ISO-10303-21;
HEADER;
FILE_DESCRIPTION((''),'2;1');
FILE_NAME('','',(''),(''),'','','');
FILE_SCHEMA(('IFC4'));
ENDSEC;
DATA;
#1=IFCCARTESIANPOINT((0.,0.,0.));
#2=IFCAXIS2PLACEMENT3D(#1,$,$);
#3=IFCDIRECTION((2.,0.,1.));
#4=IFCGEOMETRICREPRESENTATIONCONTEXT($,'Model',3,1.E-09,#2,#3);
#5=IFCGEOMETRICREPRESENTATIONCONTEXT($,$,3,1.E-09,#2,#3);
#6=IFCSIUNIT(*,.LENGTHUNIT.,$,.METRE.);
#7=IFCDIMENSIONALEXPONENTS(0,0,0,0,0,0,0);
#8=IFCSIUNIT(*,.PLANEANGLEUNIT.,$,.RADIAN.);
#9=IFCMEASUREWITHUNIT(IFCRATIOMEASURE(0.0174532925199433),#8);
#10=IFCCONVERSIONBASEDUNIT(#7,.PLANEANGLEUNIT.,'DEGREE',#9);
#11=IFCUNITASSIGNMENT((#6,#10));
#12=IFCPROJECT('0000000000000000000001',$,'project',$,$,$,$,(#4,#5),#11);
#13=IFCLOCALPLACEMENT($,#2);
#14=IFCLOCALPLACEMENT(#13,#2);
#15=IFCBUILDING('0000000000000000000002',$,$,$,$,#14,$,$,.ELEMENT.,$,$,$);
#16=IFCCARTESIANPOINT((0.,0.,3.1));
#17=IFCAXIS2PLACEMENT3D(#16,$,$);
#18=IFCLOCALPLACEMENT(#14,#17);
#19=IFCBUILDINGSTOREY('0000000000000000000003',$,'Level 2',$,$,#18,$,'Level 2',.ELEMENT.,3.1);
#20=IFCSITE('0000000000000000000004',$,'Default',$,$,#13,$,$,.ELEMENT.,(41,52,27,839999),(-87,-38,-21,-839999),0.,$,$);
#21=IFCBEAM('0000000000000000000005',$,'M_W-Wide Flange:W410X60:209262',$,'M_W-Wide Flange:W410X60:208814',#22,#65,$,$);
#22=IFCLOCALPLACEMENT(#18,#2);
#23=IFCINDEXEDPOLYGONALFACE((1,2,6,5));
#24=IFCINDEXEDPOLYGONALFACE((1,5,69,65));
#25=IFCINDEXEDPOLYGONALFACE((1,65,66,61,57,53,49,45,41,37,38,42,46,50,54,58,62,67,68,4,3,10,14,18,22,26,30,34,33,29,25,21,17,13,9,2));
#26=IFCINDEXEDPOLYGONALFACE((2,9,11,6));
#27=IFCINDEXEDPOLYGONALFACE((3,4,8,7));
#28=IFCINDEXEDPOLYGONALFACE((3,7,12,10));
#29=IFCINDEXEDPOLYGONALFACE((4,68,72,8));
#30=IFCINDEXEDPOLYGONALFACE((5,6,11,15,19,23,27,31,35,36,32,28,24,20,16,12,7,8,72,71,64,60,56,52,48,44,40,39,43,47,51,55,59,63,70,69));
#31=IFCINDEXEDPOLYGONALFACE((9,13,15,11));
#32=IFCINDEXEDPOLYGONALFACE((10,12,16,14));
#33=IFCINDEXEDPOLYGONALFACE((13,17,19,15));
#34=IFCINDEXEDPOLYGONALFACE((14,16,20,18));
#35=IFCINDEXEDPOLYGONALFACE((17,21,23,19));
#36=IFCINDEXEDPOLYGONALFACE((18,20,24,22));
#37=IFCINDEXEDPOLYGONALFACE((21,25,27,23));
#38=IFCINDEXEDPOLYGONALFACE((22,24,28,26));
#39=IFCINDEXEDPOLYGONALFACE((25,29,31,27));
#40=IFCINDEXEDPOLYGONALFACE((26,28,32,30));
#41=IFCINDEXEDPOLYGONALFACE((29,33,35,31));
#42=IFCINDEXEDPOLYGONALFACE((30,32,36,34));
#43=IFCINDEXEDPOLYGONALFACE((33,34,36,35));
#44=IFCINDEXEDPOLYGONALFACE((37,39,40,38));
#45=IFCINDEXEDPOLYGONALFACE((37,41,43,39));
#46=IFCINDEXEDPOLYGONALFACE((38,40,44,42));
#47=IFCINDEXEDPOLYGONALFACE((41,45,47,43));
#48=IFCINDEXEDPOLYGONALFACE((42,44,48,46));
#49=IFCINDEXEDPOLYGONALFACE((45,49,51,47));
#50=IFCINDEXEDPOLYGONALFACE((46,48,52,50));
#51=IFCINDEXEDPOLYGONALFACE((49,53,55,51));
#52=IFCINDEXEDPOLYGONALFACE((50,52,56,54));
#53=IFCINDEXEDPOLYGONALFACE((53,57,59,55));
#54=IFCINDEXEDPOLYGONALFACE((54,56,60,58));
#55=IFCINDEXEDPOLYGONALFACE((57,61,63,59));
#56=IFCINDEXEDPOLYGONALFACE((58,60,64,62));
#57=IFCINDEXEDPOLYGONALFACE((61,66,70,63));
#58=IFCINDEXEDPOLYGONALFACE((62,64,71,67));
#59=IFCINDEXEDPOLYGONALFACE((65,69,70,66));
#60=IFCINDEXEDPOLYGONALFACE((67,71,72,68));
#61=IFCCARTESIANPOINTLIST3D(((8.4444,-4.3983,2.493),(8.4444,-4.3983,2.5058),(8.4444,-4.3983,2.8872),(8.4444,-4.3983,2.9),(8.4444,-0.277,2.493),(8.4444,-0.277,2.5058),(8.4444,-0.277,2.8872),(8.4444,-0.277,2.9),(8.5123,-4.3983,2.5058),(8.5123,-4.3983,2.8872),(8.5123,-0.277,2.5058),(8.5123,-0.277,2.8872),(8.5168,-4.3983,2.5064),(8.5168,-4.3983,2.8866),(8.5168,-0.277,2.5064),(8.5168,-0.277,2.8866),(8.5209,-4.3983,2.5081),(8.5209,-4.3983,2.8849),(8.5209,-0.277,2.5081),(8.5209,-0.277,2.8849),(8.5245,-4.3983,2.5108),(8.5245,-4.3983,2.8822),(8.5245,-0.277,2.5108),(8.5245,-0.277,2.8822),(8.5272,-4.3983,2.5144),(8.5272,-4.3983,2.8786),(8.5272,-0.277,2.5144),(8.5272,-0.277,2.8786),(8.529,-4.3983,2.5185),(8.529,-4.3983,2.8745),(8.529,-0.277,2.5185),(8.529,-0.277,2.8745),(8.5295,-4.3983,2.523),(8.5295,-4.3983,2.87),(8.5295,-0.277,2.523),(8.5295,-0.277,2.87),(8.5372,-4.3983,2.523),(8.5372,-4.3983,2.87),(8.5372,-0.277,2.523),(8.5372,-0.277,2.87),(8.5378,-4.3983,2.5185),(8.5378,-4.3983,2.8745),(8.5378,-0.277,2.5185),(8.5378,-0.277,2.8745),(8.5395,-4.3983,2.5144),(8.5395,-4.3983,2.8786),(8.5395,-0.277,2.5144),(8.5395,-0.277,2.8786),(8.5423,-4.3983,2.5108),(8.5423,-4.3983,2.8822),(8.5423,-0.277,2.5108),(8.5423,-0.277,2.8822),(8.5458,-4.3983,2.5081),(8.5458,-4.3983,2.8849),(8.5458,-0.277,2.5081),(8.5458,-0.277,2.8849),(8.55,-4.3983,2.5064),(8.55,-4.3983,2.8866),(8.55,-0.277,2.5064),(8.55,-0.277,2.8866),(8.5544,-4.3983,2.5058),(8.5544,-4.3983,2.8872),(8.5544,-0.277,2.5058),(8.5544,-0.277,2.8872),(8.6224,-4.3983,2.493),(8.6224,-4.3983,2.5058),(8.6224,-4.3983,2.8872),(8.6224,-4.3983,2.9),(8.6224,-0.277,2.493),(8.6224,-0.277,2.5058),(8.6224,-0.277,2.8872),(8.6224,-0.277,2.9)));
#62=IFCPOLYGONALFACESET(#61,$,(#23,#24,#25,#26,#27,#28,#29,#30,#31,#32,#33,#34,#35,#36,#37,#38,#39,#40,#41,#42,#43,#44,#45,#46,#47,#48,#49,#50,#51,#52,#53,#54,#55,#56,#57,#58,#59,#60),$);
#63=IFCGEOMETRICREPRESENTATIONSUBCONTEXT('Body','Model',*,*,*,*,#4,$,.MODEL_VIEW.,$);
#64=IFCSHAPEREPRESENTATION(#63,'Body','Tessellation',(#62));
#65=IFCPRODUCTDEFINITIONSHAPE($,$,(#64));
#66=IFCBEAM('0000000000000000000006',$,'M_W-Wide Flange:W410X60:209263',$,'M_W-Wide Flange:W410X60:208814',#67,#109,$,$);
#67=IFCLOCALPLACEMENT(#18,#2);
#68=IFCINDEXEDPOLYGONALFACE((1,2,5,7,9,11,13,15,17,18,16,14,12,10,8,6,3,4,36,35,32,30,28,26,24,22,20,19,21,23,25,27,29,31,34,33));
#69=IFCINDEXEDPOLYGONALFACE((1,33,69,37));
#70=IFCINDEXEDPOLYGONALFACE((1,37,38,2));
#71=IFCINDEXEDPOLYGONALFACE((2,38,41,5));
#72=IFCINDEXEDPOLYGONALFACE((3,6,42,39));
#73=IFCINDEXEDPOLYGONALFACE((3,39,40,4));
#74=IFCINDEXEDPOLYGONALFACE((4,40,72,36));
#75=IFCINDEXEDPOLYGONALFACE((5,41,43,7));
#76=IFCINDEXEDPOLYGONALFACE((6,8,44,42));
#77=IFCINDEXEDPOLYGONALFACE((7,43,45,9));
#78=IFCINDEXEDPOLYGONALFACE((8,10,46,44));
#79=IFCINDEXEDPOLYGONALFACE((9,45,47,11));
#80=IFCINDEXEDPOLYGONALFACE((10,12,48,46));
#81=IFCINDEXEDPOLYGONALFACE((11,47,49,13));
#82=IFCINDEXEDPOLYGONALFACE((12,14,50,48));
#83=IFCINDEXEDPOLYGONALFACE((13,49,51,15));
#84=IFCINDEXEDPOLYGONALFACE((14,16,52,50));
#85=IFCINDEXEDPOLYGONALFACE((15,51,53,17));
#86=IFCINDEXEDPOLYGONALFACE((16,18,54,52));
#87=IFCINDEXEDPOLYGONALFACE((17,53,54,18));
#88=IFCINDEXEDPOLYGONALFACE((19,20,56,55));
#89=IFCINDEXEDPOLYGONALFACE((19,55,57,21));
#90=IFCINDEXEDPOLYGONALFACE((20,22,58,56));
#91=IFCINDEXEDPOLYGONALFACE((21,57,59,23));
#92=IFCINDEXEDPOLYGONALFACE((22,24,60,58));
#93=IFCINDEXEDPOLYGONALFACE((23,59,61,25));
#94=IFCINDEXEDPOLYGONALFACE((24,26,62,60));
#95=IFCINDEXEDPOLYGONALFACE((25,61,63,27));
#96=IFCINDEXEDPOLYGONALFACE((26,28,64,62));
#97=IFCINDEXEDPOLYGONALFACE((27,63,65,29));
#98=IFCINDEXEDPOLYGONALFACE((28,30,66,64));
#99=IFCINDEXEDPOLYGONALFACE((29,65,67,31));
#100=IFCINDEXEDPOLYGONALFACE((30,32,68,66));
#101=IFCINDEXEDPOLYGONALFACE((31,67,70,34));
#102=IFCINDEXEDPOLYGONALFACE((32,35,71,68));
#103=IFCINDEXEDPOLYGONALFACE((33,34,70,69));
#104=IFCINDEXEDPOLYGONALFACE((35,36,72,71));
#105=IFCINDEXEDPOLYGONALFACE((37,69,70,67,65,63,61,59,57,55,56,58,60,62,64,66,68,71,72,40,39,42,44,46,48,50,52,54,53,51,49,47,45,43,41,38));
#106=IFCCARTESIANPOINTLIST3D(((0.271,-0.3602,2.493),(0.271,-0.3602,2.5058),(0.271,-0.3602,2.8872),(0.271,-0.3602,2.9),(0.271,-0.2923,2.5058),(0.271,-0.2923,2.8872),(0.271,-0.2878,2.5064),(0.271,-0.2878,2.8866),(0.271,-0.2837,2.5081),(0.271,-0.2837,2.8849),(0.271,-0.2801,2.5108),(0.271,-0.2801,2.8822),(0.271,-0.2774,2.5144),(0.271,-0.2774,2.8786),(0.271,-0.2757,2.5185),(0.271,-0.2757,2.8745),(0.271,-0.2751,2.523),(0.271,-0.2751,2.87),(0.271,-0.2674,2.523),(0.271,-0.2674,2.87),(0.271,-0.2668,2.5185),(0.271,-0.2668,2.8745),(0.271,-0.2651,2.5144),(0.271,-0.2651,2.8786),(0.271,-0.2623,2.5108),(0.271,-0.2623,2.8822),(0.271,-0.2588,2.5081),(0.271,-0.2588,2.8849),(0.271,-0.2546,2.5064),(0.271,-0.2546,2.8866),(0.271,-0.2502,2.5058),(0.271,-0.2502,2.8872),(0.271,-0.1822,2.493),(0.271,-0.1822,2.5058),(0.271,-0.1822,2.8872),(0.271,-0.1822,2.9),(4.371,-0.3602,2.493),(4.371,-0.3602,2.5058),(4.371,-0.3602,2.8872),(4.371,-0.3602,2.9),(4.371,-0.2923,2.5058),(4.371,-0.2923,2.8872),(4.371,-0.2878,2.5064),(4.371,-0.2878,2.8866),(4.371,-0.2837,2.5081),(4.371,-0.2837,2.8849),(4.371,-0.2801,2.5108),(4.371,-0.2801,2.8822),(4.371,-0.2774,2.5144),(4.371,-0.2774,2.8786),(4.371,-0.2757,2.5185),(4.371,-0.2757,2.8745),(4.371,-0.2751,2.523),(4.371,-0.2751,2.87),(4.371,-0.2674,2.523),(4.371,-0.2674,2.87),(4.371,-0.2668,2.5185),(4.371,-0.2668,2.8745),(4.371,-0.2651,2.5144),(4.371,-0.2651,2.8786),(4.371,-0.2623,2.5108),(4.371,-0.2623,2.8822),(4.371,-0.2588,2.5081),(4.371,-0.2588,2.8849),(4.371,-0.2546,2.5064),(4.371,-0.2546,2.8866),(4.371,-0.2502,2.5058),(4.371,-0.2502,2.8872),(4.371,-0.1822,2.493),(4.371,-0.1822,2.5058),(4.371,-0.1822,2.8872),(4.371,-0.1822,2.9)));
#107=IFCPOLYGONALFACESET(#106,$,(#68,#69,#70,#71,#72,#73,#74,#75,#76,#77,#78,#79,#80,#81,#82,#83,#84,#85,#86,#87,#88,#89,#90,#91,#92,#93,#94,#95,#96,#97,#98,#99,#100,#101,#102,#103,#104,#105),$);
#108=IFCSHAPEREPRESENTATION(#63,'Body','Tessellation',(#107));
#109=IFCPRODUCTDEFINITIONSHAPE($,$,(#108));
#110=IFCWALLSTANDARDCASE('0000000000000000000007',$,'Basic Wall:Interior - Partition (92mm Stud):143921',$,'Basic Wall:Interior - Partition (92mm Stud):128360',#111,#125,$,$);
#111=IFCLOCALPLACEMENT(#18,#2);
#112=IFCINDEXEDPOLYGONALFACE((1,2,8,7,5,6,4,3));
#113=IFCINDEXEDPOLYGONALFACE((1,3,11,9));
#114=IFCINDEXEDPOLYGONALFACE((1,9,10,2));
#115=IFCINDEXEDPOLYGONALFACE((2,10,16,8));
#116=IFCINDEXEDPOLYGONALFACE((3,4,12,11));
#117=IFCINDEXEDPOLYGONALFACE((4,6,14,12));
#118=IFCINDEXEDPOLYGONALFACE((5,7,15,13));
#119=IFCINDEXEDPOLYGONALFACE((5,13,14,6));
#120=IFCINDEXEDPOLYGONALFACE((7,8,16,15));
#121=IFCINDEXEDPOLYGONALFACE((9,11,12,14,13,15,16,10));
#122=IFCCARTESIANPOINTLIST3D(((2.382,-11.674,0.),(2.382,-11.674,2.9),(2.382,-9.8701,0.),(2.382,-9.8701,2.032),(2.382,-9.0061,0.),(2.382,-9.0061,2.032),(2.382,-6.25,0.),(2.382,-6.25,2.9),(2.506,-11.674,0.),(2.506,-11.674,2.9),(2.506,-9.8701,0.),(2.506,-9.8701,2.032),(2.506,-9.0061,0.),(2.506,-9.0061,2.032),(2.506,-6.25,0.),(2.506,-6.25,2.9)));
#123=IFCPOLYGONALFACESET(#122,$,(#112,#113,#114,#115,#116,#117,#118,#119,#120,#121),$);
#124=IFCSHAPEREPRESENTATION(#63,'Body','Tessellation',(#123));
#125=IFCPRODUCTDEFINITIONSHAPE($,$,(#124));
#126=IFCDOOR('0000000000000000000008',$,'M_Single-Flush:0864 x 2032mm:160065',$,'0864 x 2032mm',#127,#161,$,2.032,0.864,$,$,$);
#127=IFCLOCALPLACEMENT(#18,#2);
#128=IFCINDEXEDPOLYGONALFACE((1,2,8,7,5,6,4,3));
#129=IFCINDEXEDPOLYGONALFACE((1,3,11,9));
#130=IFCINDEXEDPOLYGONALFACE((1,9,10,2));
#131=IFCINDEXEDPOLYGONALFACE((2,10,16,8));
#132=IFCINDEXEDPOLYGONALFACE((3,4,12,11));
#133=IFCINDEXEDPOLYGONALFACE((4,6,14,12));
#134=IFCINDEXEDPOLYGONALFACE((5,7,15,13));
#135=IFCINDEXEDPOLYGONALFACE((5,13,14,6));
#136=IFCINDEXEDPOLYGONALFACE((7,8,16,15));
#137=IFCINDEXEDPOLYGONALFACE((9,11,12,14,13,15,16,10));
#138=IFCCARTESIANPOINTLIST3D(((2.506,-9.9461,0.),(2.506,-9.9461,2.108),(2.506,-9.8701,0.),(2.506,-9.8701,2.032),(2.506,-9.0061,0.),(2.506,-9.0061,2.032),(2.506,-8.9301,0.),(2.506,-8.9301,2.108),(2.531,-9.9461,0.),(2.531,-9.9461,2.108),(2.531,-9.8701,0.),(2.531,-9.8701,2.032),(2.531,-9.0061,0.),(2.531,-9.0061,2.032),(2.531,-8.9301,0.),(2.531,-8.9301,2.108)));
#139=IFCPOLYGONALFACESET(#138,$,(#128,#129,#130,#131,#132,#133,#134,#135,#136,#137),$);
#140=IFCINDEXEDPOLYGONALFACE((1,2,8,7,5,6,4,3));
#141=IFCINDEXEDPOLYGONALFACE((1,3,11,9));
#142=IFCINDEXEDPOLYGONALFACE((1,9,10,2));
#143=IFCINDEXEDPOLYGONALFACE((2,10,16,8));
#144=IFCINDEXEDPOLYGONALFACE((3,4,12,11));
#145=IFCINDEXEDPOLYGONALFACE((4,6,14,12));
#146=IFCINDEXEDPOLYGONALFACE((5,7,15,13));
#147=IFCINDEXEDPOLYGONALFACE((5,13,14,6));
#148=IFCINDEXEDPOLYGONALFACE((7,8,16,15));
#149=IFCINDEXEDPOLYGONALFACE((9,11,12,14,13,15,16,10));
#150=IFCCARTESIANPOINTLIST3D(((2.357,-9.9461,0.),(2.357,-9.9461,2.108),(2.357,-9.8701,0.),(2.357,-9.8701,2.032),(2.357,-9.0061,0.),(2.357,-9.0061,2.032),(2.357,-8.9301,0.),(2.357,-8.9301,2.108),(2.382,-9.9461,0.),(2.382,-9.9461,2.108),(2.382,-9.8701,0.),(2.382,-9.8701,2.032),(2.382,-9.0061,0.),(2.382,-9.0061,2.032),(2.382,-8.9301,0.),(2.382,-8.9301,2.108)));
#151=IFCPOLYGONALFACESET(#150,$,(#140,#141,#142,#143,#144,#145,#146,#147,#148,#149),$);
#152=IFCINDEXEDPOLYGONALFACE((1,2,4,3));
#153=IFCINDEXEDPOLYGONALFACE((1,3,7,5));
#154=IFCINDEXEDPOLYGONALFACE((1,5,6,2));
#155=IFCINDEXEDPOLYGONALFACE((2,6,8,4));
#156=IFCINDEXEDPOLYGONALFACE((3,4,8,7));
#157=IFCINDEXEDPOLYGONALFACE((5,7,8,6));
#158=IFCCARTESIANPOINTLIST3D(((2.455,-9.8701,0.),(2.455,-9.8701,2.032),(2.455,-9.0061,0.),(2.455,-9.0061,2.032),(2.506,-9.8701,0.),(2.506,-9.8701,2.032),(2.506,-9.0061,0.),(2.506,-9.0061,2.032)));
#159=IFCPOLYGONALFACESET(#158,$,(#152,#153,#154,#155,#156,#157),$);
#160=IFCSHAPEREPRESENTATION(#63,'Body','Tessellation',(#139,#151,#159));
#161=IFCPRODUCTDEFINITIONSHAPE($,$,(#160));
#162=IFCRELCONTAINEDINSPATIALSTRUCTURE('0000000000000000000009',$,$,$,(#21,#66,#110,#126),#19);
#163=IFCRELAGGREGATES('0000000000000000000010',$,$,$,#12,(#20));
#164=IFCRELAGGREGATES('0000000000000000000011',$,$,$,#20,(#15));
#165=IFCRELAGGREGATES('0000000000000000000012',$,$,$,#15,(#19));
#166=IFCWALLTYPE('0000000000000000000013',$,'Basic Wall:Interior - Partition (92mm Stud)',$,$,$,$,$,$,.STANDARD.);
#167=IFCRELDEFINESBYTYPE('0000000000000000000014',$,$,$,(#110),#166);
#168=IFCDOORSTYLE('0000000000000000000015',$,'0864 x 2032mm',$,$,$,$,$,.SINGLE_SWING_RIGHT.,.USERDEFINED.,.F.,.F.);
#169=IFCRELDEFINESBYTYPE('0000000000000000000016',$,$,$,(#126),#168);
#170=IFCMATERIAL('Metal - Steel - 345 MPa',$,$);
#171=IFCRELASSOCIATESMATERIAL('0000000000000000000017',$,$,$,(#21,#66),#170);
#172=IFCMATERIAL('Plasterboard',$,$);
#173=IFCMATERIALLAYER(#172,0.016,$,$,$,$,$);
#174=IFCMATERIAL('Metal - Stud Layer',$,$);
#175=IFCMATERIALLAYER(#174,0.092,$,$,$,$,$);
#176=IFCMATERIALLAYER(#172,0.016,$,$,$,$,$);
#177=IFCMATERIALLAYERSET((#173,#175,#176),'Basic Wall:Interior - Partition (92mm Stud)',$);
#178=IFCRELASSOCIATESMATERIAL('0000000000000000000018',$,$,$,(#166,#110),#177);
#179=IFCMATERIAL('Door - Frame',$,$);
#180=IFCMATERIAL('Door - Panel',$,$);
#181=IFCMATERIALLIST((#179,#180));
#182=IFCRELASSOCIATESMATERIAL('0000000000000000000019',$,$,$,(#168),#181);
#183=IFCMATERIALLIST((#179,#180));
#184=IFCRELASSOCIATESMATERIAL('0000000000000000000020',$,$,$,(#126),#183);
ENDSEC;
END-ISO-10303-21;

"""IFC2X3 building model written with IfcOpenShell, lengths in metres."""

from ifc_helpers import new_model, entity, si_unit, converted_unit, direction, frame, frame_2d, origin, origin_2d_with_axis, place, context, subcontext, project, spatial, polyline, rectangle, i_section, outline, extrude, source, transform, mapped, material, material_list, layer, layer_set, layer_usage, type_object, type_shapes, element, fill, save


model = new_model("IFC2X3")

# Units and contexts
model_context = context("Model", 3, precision=1e-09, world=origin(), true_north=direction((2.0, 0.0, 1.0)))
context_of_model = context(None, 3, precision=1e-09, world=origin(), true_north=direction((2.0, 0.0, 1.0)))
body_context = subcontext(model_context, "Body", "Model", "MODEL_VIEW")
ifc_project = project(units=[si_unit("LENGTHUNIT", "METRE"), converted_unit("PLANEANGLEUNIT", "DEGREE", entity("IfcRatioMeasure", 0.0174532925199433), si_unit("PLANEANGLEUNIT", "RADIAN"), dimensions=[0, 0, 0, 0, 0, 0, 0])], contexts=[model_context, context_of_model])

# Site, building, storey
site_placement = place(None, origin())
site = spatial("IfcSite", under=ifc_project, at=site_placement, Name="Default", CompositionType="ELEMENT", RefLatitude=(41, 52, 27, 839999), RefLongitude=(-87, -38, -21, -839999), RefElevation=0.0)
building_placement = place(site_placement, origin())
building = spatial("IfcBuilding", under=site, at=building_placement, CompositionType="ELEMENT")
storey_placement = place(building_placement, frame((0.0, 0.0, 3.1)))
storey = spatial("IfcBuildingStorey", under=building, at=storey_placement, Name="Level 2", LongName="Level 2", CompositionType="ELEMENT", Elevation=3.1)

# Beams
ifc_material_1 = material(Name="Metal - Steel - 345 MPa")
beam_1_placement = place(storey_placement, frame((8.5334, -4.3983, 2.9), z_axis=(0.0, 0.0, 1.0), x_axis=(0.0, 1.0, 0.0)))
element("IfcBeam", 1, at=beam_1_placement, inside=storey, material=ifc_material_1, Name="M_W-Wide Flange:W410X60:209262", ObjectType="M_W-Wide Flange:W410X60:208814", context=body_context, shape_type="SweptSolid", body=[
    extrude(i_section(OverallWidth=0.178, OverallDepth=0.407, WebThickness=0.0077, FlangeThickness=0.0128, FilletRadius=0.0172, at=frame_2d((0.0, 0.0), x_axis=(0.0, 1.0))), frame((0.0, 0.0, -0.2035), z_axis=(1.0, 0.0, 0.0), x_axis=(0.0, 0.0, -1.0)), (0.0, 0.0, 1.0), 4.1213),
])
beam_2_placement = place(storey_placement, frame((4.371, -0.2712, 2.9), z_axis=(0.0, 0.0, 1.0), x_axis=(-1.0, 0.0, 0.0)))
element("IfcBeam", 2, at=beam_2_placement, inside=storey, material=ifc_material_1, Name="M_W-Wide Flange:W410X60:209263", ObjectType="M_W-Wide Flange:W410X60:208814", context=body_context, shape_type="SweptSolid", body=[
    extrude(i_section(OverallWidth=0.178, OverallDepth=0.407, WebThickness=0.0077, FlangeThickness=0.0128, FilletRadius=0.0172, at=frame_2d((0.0, 0.0), x_axis=(0.0, 1.0))), frame((0.0, 0.0, -0.2035), z_axis=(1.0, 0.0, 0.0), x_axis=(0.0, 0.0, -1.0)), (0.0, 0.0, 1.0), 4.1),
])

# Shared definitions
ifc_material_2 = material(Name="Metal - Stud Layer")
ifc_material_3 = material(Name="Plasterboard")

# Wall, opening, door
ifc_layer_1 = layer(ifc_material_3, 0.016)
ifc_layer_2 = layer(ifc_material_2, 0.092)
ifc_layer_3 = layer(ifc_material_3, 0.016)
ifc_layer_set_1 = layer_set([ifc_layer_1, ifc_layer_2, ifc_layer_3], Name="Basic Wall:Interior - Partition (92mm Stud)")
ifc_layer_usage_1 = layer_usage(ifc_layer_set_1, "AXIS2", "NEGATIVE", 0.062)
wall_type_1 = type_object("IfcWallType", Name="Basic Wall:Interior - Partition (92mm Stud)", PredefinedType="STANDARD", material=ifc_layer_set_1)
wall_1_placement = place(storey_placement, frame((2.444, -6.25, 0.0), z_axis=(0.0, 0.0, 1.0), x_axis=(0.0, -1.0, 0.0)))
wall_1 = element("IfcWallStandardCase", 3, at=wall_1_placement, inside=storey, type_object=wall_type_1, material=ifc_layer_usage_1, Name="Basic Wall:Interior - Partition (92mm Stud):143921", ObjectType="Basic Wall:Interior - Partition (92mm Stud):128360", context=body_context, shape_type="SweptSolid", body=[
    extrude(rectangle(XDim=5.424, YDim=0.124, at=frame_2d((2.712, 0.0), x_axis=(-1.0, 0.0))), origin(), (0.0, 0.0, 1.0), 2.9),
])
opening_1_placement = place(wall_1_placement, frame((2.7561, -0.062, 0.0)))
opening_1 = element("IfcOpeningElement", 4, at=opening_1_placement, cuts=wall_1, ObjectType="Opening", context=body_context, shape_type="SweptSolid", body=[
    extrude(rectangle(XDim=0.864, YDim=2.032, at=frame_2d((1.016, 0.432), x_axis=(0.0, 1.0))), frame((0.0, 0.0, 0.0), z_axis=(0.0, 1.0, 0.0), x_axis=(0.0, 0.0, 1.0)), (0.0, 0.0, 1.0), 0.124),
])
ifc_material_4 = material(Name="Door - Frame")
ifc_material_5 = material(Name="Door - Panel")
ifc_material_list_1 = material_list([ifc_material_4, ifc_material_5])
ifc_material_list_2 = material_list([ifc_material_4, ifc_material_5])
door_style_1 = type_object("IfcDoorStyle", Name="0864 x 2032mm", ConstructionType="USERDEFINED", OperationType="SINGLE_SWING_RIGHT", ParameterTakesPrecedence=False, Sizeable=False, material=ifc_material_list_2)
shared_shape_1 = source(origin(), body_context, "Body", "SweptSolid", [
    extrude(outline(polyline([(-0.508, -1.073), (0.508, -1.073), (0.508, 1.035), (0.432, 1.035), (0.432, -0.997), (-0.432, -0.997), (-0.432, 1.035), (-0.508, 1.035), (-0.508, -1.073)])), frame((0.432, 0.124, 1.035), z_axis=(0.0, 1.0, 0.0), x_axis=(1.0, 0.0, 0.0)), (0.0, 0.0, 1.0), 0.025),
    extrude(outline(polyline([(-1.073, -0.508), (1.035, -0.508), (1.035, -0.432), (-0.997, -0.432), (-0.997, 0.432), (1.035, 0.432), (1.035, 0.508), (-1.073, 0.508), (-1.073, -0.508)])), frame((0.432, -0.025, 1.035), z_axis=(0.0, 1.0, 0.0), x_axis=(0.0, 0.0, -1.0)), (0.0, 0.0, 1.0), 0.025),
    extrude(rectangle(XDim=0.051, YDim=0.864, at=origin_2d_with_axis()), frame((0.432, 0.0985, 0.0), z_axis=(0.0, 0.0, 1.0), x_axis=(0.0, 1.0, 0.0)), (0.0, 0.0, 1.0), 2.032),
])
type_shapes(door_style_1, [shared_shape_1])
door_1_placement = place(opening_1_placement, origin())
door_1 = element("IfcDoor", 5, at=door_1_placement, inside=storey, type_object=door_style_1, material=ifc_material_list_1, Name="M_Single-Flush:0864 x 2032mm:160065", ObjectType="0864 x 2032mm", OverallHeight=2.032, OverallWidth=0.864, context=body_context, shape_type="MappedRepresentation", body=[
    mapped(shared_shape_1, transform((0.0, 0.0, 0.0), scale=1.0)),
])
fill(opening_1, door_1)

save(model, "model.ifc")
